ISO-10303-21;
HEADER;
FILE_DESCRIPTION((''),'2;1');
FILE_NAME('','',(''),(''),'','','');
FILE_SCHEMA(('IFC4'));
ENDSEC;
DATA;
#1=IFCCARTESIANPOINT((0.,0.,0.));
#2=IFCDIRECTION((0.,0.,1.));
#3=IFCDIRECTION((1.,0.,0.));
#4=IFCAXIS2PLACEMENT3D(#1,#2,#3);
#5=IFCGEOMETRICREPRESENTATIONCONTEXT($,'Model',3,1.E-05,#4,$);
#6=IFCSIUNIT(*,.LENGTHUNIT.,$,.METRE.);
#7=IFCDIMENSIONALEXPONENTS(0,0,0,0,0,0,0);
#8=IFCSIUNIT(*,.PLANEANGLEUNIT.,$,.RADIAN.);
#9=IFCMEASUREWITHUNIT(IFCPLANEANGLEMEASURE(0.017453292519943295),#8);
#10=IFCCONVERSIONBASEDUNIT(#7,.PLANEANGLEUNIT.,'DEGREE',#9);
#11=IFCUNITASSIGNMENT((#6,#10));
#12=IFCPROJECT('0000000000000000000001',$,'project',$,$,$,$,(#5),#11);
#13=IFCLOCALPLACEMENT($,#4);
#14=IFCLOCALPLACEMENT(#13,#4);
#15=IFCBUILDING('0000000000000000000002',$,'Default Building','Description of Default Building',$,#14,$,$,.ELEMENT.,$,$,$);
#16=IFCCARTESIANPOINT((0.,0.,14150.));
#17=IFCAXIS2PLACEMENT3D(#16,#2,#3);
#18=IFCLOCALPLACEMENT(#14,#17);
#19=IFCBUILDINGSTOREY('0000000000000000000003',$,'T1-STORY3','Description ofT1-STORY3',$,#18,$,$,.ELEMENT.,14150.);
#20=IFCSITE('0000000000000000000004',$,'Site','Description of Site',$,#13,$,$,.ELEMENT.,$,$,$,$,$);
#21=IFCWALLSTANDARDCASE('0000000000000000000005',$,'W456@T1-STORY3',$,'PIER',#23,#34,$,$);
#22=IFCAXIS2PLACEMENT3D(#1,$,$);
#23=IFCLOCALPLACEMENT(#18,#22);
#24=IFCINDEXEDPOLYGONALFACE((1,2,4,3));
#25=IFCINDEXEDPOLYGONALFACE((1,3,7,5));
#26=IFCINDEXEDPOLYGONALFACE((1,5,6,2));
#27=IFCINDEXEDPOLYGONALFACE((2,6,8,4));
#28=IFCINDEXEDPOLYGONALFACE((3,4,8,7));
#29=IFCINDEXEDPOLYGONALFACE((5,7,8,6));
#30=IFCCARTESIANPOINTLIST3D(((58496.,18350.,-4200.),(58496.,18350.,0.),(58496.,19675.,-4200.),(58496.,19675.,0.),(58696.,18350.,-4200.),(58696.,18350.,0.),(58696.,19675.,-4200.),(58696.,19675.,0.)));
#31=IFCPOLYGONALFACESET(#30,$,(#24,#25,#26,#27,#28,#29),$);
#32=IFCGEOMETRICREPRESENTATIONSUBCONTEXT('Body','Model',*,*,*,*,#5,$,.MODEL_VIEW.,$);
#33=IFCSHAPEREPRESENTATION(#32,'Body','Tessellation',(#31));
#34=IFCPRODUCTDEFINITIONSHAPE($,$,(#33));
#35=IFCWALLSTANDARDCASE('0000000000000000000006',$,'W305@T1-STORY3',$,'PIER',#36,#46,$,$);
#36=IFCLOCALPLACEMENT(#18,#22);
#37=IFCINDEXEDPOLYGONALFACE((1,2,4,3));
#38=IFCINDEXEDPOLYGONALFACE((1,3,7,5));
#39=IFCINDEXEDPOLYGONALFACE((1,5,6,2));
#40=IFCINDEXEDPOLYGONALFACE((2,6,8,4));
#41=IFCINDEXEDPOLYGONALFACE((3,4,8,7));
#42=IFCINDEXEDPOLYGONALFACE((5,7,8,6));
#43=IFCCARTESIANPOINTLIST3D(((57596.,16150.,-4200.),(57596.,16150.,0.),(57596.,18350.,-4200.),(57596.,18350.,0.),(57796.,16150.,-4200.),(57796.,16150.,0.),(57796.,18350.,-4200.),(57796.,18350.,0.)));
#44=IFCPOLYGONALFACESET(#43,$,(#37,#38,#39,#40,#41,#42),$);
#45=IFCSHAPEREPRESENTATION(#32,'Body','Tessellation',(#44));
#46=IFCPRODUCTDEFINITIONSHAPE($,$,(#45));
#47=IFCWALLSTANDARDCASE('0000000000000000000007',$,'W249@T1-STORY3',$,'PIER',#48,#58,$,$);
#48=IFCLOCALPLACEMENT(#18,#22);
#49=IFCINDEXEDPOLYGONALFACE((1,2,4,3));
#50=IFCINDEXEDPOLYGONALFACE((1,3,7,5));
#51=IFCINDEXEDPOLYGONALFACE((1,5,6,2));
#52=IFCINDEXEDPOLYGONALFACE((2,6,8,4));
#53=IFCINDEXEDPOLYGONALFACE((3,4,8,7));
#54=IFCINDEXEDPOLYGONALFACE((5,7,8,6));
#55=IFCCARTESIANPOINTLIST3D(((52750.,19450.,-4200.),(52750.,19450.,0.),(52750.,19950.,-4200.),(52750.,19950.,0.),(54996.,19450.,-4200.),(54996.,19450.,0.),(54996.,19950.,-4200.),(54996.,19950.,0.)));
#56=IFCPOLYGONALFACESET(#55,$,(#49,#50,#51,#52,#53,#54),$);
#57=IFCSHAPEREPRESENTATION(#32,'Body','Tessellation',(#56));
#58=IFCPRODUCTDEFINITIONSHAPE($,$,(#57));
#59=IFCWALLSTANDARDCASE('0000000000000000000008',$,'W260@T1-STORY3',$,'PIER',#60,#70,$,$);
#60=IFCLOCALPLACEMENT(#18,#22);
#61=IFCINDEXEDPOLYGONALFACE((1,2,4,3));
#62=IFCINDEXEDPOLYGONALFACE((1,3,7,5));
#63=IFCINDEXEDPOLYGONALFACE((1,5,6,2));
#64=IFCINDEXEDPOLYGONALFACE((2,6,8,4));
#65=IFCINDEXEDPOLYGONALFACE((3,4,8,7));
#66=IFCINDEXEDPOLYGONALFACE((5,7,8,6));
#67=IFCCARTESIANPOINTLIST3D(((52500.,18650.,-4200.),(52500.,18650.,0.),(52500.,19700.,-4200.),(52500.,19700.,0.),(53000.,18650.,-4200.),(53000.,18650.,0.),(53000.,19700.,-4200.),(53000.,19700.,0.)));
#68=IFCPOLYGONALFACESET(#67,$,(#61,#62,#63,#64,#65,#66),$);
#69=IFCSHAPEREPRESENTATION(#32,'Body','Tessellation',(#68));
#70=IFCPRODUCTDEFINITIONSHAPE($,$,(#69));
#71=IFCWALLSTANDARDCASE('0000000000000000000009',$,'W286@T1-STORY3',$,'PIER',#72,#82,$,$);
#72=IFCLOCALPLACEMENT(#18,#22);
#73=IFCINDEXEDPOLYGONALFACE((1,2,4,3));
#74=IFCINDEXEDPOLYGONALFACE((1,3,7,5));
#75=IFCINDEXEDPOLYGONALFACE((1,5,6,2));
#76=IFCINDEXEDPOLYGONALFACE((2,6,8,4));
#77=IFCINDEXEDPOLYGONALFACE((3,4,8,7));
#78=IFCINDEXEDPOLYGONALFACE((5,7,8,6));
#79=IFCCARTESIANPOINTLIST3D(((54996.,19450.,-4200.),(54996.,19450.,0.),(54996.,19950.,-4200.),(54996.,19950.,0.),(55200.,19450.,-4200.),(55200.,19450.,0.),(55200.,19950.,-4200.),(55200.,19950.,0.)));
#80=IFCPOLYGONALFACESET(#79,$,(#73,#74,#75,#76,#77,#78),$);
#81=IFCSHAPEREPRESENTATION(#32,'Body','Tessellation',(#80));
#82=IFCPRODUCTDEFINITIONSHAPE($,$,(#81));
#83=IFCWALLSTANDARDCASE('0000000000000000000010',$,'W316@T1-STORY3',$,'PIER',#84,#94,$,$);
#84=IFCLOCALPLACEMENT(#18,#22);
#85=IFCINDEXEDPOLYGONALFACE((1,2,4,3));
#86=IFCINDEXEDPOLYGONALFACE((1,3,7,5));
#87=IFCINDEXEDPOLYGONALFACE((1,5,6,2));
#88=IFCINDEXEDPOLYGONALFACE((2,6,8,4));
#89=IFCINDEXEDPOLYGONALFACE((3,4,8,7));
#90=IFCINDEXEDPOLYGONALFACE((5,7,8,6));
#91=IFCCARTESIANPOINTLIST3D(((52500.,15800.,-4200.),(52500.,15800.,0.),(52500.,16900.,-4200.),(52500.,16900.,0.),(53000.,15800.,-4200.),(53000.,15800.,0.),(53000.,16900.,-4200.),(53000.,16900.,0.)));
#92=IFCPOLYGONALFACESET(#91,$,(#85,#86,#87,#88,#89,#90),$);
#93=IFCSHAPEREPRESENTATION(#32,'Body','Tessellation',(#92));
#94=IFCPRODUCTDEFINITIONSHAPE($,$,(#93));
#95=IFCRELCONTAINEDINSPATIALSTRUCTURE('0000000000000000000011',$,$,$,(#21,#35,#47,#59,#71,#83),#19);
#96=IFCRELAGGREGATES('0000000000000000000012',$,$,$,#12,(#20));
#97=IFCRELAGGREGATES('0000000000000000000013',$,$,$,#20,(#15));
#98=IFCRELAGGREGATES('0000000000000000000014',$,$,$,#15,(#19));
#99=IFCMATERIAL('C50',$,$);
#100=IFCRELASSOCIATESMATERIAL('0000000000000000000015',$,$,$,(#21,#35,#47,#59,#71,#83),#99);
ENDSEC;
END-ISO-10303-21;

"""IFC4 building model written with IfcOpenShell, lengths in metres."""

from ifc_helpers import new_model, entity, si_unit, converted_unit, frame, origin_with_axes, place, context, subcontext, project, spatial, indexed_curve, outline, extrude, material, element, save


model = new_model("IFC4")

# Units and contexts
model_context = context("Model", 3, precision=1e-05, world=origin_with_axes())
body_context = subcontext(model_context, "Body", "Model", "MODEL_VIEW")
ifc_project = project(units=[si_unit("LENGTHUNIT", "METRE"), converted_unit("PLANEANGLEUNIT", "DEGREE", entity("IfcPlaneAngleMeasure", 0.017453292519943295), si_unit("PLANEANGLEUNIT", "RADIAN"), dimensions=[0, 0, 0, 0, 0, 0, 0])], contexts=[model_context])

# Site, building, storey
site_placement = place(None, origin_with_axes())
site = spatial("IfcSite", under=ifc_project, at=site_placement, Name="Site", Description="Description of Site", CompositionType="ELEMENT")
building_placement = place(site_placement, origin_with_axes())
building = spatial("IfcBuilding", under=site, at=building_placement, Name="Default Building", Description="Description of Default Building", CompositionType="ELEMENT")
storey_placement = place(building_placement, frame((0.0, 0.0, 14150.0), z_axis=(0.0, 0.0, 1.0), x_axis=(1.0, 0.0, 0.0)))
storey = spatial("IfcBuildingStorey", under=building, at=storey_placement, Name="T1-STORY3", Description="Description ofT1-STORY3", CompositionType="ELEMENT", Elevation=14150.0)

# Shared definitions
ifc_material_1 = material(Name="C50")

# Walls
wall_1_placement = place(storey_placement, frame((58596.0, 18350.0, -4200.0), z_axis=(0.0, 0.0, 1.0), x_axis=(0.0, 1.0, 0.0)))
element("IfcWallStandardCase", 1, at=wall_1_placement, inside=storey, material=ifc_material_1, Name="W456@T1-STORY3", ObjectType="PIER", context=body_context, shape_type="SweptSolid", body=[
    extrude(outline(indexed_curve([(0.0, -100.0), (0.0, 100.0), (1325.0, 100.0), (1325.0, -100.0), (0.0, -100.0)], self_intersect=False)), origin_with_axes(), (0.0, 0.0, 1.0), 4200.0),
])
wall_2_placement = place(storey_placement, frame((57696.0, 16150.0, -4200.0), z_axis=(0.0, 0.0, 1.0), x_axis=(0.0, 1.0, 0.0)))
element("IfcWallStandardCase", 2, at=wall_2_placement, inside=storey, material=ifc_material_1, Name="W305@T1-STORY3", ObjectType="PIER", context=body_context, shape_type="SweptSolid", body=[
    extrude(outline(indexed_curve([(0.0, -100.0), (0.0, 100.0), (2200.0, 100.0), (2200.0, -100.0), (0.0, -100.0)], self_intersect=False)), origin_with_axes(), (0.0, 0.0, 1.0), 4200.0),
])
wall_3_placement = place(storey_placement, frame((52750.0, 19700.0, -4200.0), z_axis=(0.0, 0.0, 1.0), x_axis=(1.0, 0.0, 0.0)))
element("IfcWallStandardCase", 3, at=wall_3_placement, inside=storey, material=ifc_material_1, Name="W249@T1-STORY3", ObjectType="PIER", context=body_context, shape_type="SweptSolid", body=[
    extrude(outline(indexed_curve([(0.0, -250.0), (0.0, 250.0), (2246.0, 250.0), (2246.0, -250.0), (0.0, -250.0)], self_intersect=False)), origin_with_axes(), (0.0, 0.0, 1.0), 4200.0),
])
wall_4_placement = place(storey_placement, frame((52750.0, 18650.0, -4200.0), z_axis=(0.0, 0.0, 1.0), x_axis=(0.0, 1.0, 0.0)))
element("IfcWallStandardCase", 4, at=wall_4_placement, inside=storey, material=ifc_material_1, Name="W260@T1-STORY3", ObjectType="PIER", context=body_context, shape_type="SweptSolid", body=[
    extrude(outline(indexed_curve([(0.0, -250.0), (0.0, 250.0), (1050.0, 250.0), (1050.0, -250.0), (0.0, -250.0)], self_intersect=False)), origin_with_axes(), (0.0, 0.0, 1.0), 4200.0),
])
wall_5_placement = place(storey_placement, frame((54996.0, 19700.0, -4200.0), z_axis=(0.0, 0.0, 1.0), x_axis=(1.0, 0.0, 0.0)))
element("IfcWallStandardCase", 5, at=wall_5_placement, inside=storey, material=ifc_material_1, Name="W286@T1-STORY3", ObjectType="PIER", context=body_context, shape_type="SweptSolid", body=[
    extrude(outline(indexed_curve([(0.0, -250.0), (0.0, 250.0), (204.0, 250.0), (204.0, -250.0), (0.0, -250.0)], self_intersect=False)), origin_with_axes(), (0.0, 0.0, 1.0), 4200.0),
])
wall_6_placement = place(storey_placement, frame((52750.0, 15800.0, -4200.0), z_axis=(0.0, 0.0, 1.0), x_axis=(0.0, 1.0, 0.0)))
element("IfcWallStandardCase", 6, at=wall_6_placement, inside=storey, material=ifc_material_1, Name="W316@T1-STORY3", ObjectType="PIER", context=body_context, shape_type="SweptSolid", body=[
    extrude(outline(indexed_curve([(0.0, -250.0), (0.0, 250.0), (1100.0, 250.0), (1100.0, -250.0), (0.0, -250.0)], self_intersect=False)), origin_with_axes(), (0.0, 0.0, 1.0), 4200.0),
])

save(model, "model.ifc")
